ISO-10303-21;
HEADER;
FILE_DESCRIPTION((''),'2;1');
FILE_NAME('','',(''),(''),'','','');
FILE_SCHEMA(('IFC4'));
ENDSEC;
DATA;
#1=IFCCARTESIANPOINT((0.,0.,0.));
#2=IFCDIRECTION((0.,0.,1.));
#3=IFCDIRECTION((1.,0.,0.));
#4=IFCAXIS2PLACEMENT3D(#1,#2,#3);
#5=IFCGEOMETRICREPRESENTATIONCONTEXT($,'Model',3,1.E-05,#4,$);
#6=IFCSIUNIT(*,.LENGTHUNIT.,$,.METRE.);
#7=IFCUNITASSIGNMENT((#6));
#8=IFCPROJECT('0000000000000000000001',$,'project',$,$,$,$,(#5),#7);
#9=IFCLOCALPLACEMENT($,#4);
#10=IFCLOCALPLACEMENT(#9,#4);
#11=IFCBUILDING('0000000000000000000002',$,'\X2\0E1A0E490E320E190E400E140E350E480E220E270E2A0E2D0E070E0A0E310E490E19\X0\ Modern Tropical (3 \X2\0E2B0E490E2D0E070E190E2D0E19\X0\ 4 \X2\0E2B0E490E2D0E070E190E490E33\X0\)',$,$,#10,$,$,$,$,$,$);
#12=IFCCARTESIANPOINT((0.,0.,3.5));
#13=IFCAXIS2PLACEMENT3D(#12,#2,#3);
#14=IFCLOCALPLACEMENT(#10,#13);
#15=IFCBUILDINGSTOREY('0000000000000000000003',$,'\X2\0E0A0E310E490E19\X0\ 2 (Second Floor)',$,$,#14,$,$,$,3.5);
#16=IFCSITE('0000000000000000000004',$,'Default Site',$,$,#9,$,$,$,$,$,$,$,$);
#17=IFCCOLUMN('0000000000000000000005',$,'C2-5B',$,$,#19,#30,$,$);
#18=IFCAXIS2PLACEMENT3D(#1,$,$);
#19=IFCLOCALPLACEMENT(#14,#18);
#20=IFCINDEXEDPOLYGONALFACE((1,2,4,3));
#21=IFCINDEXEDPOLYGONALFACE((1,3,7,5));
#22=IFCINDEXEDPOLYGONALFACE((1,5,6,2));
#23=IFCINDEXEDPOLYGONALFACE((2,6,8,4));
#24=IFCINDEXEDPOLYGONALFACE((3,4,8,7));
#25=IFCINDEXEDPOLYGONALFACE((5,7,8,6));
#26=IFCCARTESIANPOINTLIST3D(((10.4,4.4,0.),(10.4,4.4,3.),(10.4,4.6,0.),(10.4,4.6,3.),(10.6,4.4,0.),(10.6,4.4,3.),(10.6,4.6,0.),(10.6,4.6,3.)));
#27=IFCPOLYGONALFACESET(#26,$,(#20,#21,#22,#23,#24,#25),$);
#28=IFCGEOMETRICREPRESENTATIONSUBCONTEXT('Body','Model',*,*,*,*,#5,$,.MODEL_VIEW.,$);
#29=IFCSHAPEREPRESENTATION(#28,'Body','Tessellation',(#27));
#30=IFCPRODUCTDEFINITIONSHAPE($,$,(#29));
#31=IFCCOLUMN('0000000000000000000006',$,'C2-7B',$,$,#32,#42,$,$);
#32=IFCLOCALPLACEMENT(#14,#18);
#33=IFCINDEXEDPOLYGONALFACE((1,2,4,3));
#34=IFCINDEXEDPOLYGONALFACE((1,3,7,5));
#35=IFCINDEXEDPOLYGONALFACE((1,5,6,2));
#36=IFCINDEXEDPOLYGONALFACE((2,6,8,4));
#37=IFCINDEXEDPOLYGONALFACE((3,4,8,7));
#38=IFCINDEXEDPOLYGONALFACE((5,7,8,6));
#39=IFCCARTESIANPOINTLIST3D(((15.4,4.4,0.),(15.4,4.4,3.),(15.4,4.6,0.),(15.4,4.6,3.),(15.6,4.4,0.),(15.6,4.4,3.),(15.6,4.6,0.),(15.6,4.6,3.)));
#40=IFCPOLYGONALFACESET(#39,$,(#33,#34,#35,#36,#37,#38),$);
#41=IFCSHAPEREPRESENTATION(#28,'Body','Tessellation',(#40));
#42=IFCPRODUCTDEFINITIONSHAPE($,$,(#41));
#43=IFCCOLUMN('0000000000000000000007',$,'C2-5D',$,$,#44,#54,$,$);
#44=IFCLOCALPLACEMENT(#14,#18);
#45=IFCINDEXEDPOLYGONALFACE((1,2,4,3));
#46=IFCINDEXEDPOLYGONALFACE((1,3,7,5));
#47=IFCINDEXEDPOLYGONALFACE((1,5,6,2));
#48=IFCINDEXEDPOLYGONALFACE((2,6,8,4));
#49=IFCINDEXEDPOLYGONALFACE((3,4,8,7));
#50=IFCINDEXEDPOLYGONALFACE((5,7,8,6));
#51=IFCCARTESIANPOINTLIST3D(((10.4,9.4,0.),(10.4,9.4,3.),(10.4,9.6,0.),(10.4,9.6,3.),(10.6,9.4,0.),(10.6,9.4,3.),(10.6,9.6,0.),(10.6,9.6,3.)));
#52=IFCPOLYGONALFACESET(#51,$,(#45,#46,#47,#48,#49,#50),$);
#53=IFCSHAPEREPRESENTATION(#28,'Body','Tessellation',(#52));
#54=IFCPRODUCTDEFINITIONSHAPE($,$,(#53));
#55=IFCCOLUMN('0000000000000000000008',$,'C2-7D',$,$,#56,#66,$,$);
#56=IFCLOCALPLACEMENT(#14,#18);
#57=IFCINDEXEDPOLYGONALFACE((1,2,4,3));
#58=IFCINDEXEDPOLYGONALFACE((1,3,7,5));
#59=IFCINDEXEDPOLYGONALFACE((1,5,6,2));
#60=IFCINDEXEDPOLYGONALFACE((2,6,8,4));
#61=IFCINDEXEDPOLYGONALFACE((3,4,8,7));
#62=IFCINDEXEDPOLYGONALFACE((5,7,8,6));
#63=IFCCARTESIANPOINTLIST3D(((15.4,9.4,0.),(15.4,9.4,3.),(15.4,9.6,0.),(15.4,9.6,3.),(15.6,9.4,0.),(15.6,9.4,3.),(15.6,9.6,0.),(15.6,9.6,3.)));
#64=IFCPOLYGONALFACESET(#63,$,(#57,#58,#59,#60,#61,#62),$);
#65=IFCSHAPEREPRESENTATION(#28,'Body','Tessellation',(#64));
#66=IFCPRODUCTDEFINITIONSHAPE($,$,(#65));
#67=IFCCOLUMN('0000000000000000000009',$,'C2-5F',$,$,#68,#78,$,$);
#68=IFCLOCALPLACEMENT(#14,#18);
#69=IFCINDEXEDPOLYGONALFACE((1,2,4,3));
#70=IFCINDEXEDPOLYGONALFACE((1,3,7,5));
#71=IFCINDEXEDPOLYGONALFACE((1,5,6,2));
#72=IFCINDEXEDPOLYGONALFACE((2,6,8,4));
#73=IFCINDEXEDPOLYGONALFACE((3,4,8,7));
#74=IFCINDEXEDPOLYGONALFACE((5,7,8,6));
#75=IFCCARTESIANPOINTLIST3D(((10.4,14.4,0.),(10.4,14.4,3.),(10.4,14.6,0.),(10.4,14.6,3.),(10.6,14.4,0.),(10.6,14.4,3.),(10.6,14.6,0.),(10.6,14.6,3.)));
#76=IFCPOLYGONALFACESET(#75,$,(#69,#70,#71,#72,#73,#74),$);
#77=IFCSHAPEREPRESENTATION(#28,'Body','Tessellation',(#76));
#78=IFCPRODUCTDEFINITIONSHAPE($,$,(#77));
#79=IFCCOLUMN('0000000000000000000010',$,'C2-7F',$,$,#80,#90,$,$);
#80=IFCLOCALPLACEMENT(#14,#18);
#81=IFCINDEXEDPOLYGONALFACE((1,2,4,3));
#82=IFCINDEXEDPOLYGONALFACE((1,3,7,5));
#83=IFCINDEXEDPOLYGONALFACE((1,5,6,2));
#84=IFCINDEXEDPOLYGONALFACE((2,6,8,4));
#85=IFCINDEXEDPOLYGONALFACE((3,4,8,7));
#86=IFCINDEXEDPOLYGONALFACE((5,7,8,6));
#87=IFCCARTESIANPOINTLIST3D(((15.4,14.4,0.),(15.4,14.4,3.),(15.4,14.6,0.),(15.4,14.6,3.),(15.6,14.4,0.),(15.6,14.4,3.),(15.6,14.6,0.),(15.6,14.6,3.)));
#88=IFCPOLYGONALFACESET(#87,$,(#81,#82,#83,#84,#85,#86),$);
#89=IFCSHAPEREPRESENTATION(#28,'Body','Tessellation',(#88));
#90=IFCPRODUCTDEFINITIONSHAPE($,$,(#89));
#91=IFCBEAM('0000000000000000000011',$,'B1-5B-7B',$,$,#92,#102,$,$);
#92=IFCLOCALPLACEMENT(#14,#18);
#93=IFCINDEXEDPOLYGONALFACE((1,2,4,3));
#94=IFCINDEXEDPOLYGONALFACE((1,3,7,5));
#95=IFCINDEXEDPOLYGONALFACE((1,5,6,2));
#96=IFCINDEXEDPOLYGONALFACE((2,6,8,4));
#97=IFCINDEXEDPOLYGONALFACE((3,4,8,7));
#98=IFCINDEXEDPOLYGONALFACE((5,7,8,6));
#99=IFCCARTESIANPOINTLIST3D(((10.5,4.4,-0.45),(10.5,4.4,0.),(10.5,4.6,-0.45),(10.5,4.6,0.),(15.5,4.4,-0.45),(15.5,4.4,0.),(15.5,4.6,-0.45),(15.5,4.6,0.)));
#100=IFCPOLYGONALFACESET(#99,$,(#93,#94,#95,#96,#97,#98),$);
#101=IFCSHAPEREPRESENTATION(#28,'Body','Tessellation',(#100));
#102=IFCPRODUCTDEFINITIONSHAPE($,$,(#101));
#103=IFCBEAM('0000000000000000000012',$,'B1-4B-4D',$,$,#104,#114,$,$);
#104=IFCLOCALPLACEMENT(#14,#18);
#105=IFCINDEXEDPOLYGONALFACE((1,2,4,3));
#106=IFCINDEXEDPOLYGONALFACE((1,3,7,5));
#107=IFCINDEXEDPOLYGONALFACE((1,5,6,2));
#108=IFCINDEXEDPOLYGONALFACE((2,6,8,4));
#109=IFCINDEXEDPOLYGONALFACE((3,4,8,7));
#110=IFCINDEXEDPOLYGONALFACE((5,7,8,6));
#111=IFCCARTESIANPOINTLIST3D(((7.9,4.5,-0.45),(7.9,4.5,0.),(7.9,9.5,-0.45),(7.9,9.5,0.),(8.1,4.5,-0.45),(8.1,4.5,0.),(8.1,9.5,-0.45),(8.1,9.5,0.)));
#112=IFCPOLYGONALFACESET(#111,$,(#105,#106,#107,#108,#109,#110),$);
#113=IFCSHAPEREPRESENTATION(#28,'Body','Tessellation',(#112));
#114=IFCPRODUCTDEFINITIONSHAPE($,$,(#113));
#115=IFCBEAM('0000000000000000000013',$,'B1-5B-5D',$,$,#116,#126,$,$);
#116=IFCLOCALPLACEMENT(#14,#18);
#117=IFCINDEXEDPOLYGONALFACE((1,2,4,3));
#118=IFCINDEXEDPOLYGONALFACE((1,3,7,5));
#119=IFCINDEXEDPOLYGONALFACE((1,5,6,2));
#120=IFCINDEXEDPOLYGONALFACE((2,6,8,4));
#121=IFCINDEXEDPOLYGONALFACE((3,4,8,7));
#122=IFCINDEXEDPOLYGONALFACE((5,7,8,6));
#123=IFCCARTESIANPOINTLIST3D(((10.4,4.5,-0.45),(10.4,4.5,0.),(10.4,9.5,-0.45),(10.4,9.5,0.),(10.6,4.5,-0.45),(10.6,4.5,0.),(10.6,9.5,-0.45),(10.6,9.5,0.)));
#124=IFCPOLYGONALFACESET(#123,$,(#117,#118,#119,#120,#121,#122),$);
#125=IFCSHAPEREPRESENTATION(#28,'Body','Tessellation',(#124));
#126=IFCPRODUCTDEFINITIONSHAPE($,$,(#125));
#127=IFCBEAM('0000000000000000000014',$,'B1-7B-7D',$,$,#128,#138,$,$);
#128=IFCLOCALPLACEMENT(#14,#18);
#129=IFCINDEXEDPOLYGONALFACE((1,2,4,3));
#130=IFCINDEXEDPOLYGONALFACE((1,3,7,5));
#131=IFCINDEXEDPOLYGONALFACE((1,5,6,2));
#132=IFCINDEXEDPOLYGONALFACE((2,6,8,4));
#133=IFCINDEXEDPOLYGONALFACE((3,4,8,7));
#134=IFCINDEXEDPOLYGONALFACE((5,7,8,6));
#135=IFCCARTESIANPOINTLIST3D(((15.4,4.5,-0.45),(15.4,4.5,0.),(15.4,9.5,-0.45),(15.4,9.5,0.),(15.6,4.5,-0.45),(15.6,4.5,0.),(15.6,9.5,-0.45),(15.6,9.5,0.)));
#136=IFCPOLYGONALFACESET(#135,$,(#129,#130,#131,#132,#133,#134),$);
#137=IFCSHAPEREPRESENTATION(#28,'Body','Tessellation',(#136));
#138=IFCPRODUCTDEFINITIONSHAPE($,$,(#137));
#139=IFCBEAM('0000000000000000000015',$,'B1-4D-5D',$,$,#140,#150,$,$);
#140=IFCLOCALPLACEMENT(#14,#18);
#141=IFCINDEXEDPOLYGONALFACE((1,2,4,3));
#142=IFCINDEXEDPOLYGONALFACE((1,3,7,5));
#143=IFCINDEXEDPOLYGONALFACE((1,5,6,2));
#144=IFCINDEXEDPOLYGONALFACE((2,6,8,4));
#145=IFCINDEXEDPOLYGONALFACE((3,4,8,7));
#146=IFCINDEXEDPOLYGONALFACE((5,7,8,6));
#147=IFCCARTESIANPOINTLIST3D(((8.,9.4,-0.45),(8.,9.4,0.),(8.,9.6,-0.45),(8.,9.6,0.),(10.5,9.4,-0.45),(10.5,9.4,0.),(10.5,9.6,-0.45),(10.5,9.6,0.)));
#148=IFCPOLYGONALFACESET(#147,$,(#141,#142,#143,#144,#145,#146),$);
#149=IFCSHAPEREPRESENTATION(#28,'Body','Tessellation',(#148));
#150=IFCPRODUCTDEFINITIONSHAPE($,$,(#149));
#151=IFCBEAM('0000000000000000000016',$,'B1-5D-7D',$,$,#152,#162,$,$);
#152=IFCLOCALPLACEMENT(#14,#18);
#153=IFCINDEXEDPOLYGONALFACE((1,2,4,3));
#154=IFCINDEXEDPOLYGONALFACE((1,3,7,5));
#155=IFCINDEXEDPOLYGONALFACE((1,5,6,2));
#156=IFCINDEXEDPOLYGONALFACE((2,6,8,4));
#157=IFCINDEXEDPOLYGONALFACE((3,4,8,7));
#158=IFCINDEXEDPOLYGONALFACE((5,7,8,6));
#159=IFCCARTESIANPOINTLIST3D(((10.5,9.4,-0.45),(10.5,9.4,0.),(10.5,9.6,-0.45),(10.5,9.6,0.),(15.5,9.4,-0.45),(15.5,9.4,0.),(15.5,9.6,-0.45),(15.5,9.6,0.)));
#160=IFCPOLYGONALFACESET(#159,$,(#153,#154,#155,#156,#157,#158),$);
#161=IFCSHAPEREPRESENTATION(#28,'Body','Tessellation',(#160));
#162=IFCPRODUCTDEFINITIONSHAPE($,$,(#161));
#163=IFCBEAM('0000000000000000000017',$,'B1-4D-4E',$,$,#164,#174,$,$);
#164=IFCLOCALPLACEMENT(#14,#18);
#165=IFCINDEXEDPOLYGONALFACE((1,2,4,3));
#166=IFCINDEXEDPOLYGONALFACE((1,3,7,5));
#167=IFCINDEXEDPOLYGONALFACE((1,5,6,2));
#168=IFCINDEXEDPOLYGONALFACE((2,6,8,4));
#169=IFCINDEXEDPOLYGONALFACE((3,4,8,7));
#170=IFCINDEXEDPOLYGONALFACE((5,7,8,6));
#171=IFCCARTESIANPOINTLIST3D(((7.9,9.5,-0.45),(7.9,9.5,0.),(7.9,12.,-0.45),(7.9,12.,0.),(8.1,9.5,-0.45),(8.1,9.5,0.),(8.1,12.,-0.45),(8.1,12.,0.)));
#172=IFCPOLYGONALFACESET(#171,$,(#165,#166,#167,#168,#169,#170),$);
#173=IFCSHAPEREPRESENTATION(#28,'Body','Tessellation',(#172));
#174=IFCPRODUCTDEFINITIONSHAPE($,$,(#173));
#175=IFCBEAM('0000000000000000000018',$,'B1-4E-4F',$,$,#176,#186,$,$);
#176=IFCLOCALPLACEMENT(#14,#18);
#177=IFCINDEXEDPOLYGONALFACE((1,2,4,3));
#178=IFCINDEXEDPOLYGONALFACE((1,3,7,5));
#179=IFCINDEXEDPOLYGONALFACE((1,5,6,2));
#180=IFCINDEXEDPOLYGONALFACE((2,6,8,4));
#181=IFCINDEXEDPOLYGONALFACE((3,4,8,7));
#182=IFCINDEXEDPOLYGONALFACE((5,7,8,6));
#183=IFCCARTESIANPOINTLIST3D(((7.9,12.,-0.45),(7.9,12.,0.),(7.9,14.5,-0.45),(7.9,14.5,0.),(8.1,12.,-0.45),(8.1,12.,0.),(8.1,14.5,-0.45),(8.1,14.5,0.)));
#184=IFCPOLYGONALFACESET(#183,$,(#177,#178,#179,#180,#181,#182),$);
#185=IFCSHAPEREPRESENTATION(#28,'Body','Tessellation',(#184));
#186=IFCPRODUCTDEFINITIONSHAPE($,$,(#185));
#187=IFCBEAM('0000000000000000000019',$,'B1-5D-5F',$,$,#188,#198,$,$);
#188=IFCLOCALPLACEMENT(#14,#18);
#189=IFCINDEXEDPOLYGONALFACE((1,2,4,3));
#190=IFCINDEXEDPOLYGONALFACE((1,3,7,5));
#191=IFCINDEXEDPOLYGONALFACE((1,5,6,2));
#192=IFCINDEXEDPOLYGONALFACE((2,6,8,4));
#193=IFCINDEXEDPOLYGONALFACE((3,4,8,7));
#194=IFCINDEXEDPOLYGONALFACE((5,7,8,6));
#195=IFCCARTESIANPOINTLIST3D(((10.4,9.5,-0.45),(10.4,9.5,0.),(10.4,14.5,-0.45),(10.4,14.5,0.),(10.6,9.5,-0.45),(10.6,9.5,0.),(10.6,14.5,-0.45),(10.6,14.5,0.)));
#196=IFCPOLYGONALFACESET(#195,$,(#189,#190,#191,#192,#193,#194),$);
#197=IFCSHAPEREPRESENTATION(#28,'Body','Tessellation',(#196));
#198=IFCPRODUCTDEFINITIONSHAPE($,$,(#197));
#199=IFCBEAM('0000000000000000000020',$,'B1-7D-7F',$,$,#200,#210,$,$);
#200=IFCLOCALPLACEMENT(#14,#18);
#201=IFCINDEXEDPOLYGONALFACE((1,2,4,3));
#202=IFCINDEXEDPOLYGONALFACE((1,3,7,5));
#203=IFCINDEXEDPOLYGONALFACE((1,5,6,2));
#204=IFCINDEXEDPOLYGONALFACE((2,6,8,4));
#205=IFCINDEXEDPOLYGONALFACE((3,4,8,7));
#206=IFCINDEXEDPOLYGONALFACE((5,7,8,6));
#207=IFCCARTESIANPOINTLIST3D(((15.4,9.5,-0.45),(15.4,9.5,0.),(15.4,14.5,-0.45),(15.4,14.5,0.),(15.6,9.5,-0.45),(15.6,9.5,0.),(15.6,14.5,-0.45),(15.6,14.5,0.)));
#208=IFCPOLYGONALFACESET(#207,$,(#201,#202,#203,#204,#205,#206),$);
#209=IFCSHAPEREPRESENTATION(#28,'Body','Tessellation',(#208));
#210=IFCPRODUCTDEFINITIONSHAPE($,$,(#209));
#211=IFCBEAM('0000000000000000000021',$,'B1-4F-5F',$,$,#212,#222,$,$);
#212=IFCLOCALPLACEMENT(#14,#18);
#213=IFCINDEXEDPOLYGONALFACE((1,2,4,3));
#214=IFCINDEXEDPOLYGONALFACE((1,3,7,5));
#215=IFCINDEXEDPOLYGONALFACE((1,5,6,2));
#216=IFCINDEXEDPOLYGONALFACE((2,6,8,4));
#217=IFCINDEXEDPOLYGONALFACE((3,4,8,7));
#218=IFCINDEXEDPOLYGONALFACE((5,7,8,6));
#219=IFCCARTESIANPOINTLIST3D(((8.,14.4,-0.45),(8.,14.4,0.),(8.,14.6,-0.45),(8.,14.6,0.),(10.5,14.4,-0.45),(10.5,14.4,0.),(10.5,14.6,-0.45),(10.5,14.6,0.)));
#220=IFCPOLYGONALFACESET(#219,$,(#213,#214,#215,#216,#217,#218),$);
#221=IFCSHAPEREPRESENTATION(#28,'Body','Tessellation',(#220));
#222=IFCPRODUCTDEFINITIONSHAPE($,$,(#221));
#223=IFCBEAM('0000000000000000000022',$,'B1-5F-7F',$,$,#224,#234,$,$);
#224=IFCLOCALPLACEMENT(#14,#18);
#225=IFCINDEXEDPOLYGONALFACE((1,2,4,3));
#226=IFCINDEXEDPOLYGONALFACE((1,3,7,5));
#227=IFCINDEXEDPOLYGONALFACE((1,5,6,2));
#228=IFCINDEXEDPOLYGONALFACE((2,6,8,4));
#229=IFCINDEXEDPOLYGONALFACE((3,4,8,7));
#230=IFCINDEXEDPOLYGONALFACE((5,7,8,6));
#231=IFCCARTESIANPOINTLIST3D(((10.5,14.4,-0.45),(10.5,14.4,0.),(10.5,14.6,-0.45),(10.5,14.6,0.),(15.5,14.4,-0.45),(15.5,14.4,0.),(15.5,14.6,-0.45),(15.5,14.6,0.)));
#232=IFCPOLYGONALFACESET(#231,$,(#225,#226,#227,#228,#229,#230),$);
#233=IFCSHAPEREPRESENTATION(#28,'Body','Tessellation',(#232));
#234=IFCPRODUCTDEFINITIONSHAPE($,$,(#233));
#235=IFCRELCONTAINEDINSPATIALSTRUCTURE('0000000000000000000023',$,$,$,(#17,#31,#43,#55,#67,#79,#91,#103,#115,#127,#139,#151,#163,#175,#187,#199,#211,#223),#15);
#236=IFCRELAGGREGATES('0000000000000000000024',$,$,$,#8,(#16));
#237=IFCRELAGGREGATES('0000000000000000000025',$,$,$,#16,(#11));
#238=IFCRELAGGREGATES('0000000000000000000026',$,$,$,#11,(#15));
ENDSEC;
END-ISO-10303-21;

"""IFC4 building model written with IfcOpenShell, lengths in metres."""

from ifc_helpers import new_model, si_unit, frame, origin_with_axes, origin_2d, place, context, subcontext, project, spatial, rectangle, extrude, element, save


model = new_model("IFC4")

# Units and contexts
model_context = context("Model", 3, precision=1e-05, world=origin_with_axes())
body_context = subcontext(model_context, "Body", "Model", "MODEL_VIEW")
ifc_project = project(units=[si_unit("LENGTHUNIT", "METRE")], contexts=[model_context])

# Site, building, storey
site_placement = place(None, origin_with_axes())
site = spatial("IfcSite", under=ifc_project, at=site_placement, Name="Default Site")
building_placement = place(site_placement, origin_with_axes())
building = spatial("IfcBuilding", under=site, at=building_placement, Name="บ้านเดี่ยวสองชั้น Modern Tropical (3 ห้องนอน 4 ห้องน้ำ)")
storey_placement = place(building_placement, frame((0.0, 0.0, 3.5), z_axis=(0.0, 0.0, 1.0), x_axis=(1.0, 0.0, 0.0)))
storey = spatial("IfcBuildingStorey", under=building, at=storey_placement, Name="ชั้น 2 (Second Floor)", Elevation=3.5)

# Columns
for number, where, z_axis, x_axis, name in (
    (1, (10.5, 4.5, 0.0), (0.0, 0.0, 1.0), (1.0, 0.0, 0.0), "C2-5B"),
    (2, (15.5, 4.5, 0.0), (0.0, 0.0, 1.0), (1.0, 0.0, 0.0), "C2-7B"),
    (3, (10.5, 9.5, 0.0), (0.0, 0.0, 1.0), (1.0, 0.0, 0.0), "C2-5D"),
    (4, (15.5, 9.5, 0.0), (0.0, 0.0, 1.0), (1.0, 0.0, 0.0), "C2-7D"),
    (5, (10.5, 14.5, 0.0), (0.0, 0.0, 1.0), (1.0, 0.0, 0.0), "C2-5F"),
    (6, (15.5, 14.5, 0.0), (0.0, 0.0, 1.0), (1.0, 0.0, 0.0), "C2-7F"),
):
    element("IfcColumn", number, at=place(storey_placement, frame(where, z_axis=z_axis, x_axis=x_axis)), inside=storey, Name=name, context=body_context, shape_type="SweptSolid", body=[
        extrude(rectangle(XDim=0.2, YDim=0.2, at=origin_2d()), origin_with_axes(), (0.0, 0.0, 1.0), 3.0),
    ])

# Beams
for number, where, z_axis, x_axis, name in (
    (7, (10.5, 4.5, -0.225), (1.0, 0.0, 0.0), (0.0, 1.0, 0.0), "B1-5B-7B"),
    (8, (8.0, 4.5, -0.225), (0.0, 1.0, 0.0), (-1.0, 0.0, 0.0), "B1-4B-4D"),
    (9, (10.5, 4.5, -0.225), (0.0, 1.0, 0.0), (-1.0, 0.0, 0.0), "B1-5B-5D"),
    (10, (15.5, 4.5, -0.225), (0.0, 1.0, 0.0), (-1.0, 0.0, 0.0), "B1-7B-7D"),
):
    element("IfcBeam", number, at=place(storey_placement, frame(where, z_axis=z_axis, x_axis=x_axis)), inside=storey, Name=name, context=body_context, shape_type="SweptSolid", body=[
        extrude(rectangle(XDim=0.2, YDim=0.45, at=origin_2d()), origin_with_axes(), (0.0, 0.0, 1.0), 5.0),
    ])
beam_1_placement = place(storey_placement, frame((8.0, 9.5, -0.225), z_axis=(1.0, 0.0, 0.0), x_axis=(0.0, 1.0, 0.0)))
element("IfcBeam", 11, at=beam_1_placement, inside=storey, Name="B1-4D-5D", context=body_context, shape_type="SweptSolid", body=[
    extrude(rectangle(XDim=0.2, YDim=0.45, at=origin_2d()), origin_with_axes(), (0.0, 0.0, 1.0), 2.5),
])
beam_2_placement = place(storey_placement, frame((10.5, 9.5, -0.225), z_axis=(1.0, 0.0, 0.0), x_axis=(0.0, 1.0, 0.0)))
element("IfcBeam", 12, at=beam_2_placement, inside=storey, Name="B1-5D-7D", context=body_context, shape_type="SweptSolid", body=[
    extrude(rectangle(XDim=0.2, YDim=0.45, at=origin_2d()), origin_with_axes(), (0.0, 0.0, 1.0), 5.0),
])
for number, where, z_axis, x_axis, name in (
    (13, (8.0, 9.5, -0.225), (0.0, 1.0, 0.0), (-1.0, 0.0, 0.0), "B1-4D-4E"),
    (14, (8.0, 12.0, -0.225), (0.0, 1.0, 0.0), (-1.0, 0.0, 0.0), "B1-4E-4F"),
):
    element("IfcBeam", number, at=place(storey_placement, frame(where, z_axis=z_axis, x_axis=x_axis)), inside=storey, Name=name, context=body_context, shape_type="SweptSolid", body=[
        extrude(rectangle(XDim=0.2, YDim=0.45, at=origin_2d()), origin_with_axes(), (0.0, 0.0, 1.0), 2.5),
    ])
for number, where, z_axis, x_axis, name in (
    (15, (10.5, 9.5, -0.225), (0.0, 1.0, 0.0), (-1.0, 0.0, 0.0), "B1-5D-5F"),
    (16, (15.5, 9.5, -0.225), (0.0, 1.0, 0.0), (-1.0, 0.0, 0.0), "B1-7D-7F"),
):
    element("IfcBeam", number, at=place(storey_placement, frame(where, z_axis=z_axis, x_axis=x_axis)), inside=storey, Name=name, context=body_context, shape_type="SweptSolid", body=[
        extrude(rectangle(XDim=0.2, YDim=0.45, at=origin_2d()), origin_with_axes(), (0.0, 0.0, 1.0), 5.0),
    ])
beam_3_placement = place(storey_placement, frame((8.0, 14.5, -0.225), z_axis=(1.0, 0.0, 0.0), x_axis=(0.0, 1.0, 0.0)))
element("IfcBeam", 17, at=beam_3_placement, inside=storey, Name="B1-4F-5F", context=body_context, shape_type="SweptSolid", body=[
    extrude(rectangle(XDim=0.2, YDim=0.45, at=origin_2d()), origin_with_axes(), (0.0, 0.0, 1.0), 2.5),
])
beam_4_placement = place(storey_placement, frame((10.5, 14.5, -0.225), z_axis=(1.0, 0.0, 0.0), x_axis=(0.0, 1.0, 0.0)))
element("IfcBeam", 18, at=beam_4_placement, inside=storey, Name="B1-5F-7F", context=body_context, shape_type="SweptSolid", body=[
    extrude(rectangle(XDim=0.2, YDim=0.45, at=origin_2d()), origin_with_axes(), (0.0, 0.0, 1.0), 5.0),
])

save(model, "model.ifc")
